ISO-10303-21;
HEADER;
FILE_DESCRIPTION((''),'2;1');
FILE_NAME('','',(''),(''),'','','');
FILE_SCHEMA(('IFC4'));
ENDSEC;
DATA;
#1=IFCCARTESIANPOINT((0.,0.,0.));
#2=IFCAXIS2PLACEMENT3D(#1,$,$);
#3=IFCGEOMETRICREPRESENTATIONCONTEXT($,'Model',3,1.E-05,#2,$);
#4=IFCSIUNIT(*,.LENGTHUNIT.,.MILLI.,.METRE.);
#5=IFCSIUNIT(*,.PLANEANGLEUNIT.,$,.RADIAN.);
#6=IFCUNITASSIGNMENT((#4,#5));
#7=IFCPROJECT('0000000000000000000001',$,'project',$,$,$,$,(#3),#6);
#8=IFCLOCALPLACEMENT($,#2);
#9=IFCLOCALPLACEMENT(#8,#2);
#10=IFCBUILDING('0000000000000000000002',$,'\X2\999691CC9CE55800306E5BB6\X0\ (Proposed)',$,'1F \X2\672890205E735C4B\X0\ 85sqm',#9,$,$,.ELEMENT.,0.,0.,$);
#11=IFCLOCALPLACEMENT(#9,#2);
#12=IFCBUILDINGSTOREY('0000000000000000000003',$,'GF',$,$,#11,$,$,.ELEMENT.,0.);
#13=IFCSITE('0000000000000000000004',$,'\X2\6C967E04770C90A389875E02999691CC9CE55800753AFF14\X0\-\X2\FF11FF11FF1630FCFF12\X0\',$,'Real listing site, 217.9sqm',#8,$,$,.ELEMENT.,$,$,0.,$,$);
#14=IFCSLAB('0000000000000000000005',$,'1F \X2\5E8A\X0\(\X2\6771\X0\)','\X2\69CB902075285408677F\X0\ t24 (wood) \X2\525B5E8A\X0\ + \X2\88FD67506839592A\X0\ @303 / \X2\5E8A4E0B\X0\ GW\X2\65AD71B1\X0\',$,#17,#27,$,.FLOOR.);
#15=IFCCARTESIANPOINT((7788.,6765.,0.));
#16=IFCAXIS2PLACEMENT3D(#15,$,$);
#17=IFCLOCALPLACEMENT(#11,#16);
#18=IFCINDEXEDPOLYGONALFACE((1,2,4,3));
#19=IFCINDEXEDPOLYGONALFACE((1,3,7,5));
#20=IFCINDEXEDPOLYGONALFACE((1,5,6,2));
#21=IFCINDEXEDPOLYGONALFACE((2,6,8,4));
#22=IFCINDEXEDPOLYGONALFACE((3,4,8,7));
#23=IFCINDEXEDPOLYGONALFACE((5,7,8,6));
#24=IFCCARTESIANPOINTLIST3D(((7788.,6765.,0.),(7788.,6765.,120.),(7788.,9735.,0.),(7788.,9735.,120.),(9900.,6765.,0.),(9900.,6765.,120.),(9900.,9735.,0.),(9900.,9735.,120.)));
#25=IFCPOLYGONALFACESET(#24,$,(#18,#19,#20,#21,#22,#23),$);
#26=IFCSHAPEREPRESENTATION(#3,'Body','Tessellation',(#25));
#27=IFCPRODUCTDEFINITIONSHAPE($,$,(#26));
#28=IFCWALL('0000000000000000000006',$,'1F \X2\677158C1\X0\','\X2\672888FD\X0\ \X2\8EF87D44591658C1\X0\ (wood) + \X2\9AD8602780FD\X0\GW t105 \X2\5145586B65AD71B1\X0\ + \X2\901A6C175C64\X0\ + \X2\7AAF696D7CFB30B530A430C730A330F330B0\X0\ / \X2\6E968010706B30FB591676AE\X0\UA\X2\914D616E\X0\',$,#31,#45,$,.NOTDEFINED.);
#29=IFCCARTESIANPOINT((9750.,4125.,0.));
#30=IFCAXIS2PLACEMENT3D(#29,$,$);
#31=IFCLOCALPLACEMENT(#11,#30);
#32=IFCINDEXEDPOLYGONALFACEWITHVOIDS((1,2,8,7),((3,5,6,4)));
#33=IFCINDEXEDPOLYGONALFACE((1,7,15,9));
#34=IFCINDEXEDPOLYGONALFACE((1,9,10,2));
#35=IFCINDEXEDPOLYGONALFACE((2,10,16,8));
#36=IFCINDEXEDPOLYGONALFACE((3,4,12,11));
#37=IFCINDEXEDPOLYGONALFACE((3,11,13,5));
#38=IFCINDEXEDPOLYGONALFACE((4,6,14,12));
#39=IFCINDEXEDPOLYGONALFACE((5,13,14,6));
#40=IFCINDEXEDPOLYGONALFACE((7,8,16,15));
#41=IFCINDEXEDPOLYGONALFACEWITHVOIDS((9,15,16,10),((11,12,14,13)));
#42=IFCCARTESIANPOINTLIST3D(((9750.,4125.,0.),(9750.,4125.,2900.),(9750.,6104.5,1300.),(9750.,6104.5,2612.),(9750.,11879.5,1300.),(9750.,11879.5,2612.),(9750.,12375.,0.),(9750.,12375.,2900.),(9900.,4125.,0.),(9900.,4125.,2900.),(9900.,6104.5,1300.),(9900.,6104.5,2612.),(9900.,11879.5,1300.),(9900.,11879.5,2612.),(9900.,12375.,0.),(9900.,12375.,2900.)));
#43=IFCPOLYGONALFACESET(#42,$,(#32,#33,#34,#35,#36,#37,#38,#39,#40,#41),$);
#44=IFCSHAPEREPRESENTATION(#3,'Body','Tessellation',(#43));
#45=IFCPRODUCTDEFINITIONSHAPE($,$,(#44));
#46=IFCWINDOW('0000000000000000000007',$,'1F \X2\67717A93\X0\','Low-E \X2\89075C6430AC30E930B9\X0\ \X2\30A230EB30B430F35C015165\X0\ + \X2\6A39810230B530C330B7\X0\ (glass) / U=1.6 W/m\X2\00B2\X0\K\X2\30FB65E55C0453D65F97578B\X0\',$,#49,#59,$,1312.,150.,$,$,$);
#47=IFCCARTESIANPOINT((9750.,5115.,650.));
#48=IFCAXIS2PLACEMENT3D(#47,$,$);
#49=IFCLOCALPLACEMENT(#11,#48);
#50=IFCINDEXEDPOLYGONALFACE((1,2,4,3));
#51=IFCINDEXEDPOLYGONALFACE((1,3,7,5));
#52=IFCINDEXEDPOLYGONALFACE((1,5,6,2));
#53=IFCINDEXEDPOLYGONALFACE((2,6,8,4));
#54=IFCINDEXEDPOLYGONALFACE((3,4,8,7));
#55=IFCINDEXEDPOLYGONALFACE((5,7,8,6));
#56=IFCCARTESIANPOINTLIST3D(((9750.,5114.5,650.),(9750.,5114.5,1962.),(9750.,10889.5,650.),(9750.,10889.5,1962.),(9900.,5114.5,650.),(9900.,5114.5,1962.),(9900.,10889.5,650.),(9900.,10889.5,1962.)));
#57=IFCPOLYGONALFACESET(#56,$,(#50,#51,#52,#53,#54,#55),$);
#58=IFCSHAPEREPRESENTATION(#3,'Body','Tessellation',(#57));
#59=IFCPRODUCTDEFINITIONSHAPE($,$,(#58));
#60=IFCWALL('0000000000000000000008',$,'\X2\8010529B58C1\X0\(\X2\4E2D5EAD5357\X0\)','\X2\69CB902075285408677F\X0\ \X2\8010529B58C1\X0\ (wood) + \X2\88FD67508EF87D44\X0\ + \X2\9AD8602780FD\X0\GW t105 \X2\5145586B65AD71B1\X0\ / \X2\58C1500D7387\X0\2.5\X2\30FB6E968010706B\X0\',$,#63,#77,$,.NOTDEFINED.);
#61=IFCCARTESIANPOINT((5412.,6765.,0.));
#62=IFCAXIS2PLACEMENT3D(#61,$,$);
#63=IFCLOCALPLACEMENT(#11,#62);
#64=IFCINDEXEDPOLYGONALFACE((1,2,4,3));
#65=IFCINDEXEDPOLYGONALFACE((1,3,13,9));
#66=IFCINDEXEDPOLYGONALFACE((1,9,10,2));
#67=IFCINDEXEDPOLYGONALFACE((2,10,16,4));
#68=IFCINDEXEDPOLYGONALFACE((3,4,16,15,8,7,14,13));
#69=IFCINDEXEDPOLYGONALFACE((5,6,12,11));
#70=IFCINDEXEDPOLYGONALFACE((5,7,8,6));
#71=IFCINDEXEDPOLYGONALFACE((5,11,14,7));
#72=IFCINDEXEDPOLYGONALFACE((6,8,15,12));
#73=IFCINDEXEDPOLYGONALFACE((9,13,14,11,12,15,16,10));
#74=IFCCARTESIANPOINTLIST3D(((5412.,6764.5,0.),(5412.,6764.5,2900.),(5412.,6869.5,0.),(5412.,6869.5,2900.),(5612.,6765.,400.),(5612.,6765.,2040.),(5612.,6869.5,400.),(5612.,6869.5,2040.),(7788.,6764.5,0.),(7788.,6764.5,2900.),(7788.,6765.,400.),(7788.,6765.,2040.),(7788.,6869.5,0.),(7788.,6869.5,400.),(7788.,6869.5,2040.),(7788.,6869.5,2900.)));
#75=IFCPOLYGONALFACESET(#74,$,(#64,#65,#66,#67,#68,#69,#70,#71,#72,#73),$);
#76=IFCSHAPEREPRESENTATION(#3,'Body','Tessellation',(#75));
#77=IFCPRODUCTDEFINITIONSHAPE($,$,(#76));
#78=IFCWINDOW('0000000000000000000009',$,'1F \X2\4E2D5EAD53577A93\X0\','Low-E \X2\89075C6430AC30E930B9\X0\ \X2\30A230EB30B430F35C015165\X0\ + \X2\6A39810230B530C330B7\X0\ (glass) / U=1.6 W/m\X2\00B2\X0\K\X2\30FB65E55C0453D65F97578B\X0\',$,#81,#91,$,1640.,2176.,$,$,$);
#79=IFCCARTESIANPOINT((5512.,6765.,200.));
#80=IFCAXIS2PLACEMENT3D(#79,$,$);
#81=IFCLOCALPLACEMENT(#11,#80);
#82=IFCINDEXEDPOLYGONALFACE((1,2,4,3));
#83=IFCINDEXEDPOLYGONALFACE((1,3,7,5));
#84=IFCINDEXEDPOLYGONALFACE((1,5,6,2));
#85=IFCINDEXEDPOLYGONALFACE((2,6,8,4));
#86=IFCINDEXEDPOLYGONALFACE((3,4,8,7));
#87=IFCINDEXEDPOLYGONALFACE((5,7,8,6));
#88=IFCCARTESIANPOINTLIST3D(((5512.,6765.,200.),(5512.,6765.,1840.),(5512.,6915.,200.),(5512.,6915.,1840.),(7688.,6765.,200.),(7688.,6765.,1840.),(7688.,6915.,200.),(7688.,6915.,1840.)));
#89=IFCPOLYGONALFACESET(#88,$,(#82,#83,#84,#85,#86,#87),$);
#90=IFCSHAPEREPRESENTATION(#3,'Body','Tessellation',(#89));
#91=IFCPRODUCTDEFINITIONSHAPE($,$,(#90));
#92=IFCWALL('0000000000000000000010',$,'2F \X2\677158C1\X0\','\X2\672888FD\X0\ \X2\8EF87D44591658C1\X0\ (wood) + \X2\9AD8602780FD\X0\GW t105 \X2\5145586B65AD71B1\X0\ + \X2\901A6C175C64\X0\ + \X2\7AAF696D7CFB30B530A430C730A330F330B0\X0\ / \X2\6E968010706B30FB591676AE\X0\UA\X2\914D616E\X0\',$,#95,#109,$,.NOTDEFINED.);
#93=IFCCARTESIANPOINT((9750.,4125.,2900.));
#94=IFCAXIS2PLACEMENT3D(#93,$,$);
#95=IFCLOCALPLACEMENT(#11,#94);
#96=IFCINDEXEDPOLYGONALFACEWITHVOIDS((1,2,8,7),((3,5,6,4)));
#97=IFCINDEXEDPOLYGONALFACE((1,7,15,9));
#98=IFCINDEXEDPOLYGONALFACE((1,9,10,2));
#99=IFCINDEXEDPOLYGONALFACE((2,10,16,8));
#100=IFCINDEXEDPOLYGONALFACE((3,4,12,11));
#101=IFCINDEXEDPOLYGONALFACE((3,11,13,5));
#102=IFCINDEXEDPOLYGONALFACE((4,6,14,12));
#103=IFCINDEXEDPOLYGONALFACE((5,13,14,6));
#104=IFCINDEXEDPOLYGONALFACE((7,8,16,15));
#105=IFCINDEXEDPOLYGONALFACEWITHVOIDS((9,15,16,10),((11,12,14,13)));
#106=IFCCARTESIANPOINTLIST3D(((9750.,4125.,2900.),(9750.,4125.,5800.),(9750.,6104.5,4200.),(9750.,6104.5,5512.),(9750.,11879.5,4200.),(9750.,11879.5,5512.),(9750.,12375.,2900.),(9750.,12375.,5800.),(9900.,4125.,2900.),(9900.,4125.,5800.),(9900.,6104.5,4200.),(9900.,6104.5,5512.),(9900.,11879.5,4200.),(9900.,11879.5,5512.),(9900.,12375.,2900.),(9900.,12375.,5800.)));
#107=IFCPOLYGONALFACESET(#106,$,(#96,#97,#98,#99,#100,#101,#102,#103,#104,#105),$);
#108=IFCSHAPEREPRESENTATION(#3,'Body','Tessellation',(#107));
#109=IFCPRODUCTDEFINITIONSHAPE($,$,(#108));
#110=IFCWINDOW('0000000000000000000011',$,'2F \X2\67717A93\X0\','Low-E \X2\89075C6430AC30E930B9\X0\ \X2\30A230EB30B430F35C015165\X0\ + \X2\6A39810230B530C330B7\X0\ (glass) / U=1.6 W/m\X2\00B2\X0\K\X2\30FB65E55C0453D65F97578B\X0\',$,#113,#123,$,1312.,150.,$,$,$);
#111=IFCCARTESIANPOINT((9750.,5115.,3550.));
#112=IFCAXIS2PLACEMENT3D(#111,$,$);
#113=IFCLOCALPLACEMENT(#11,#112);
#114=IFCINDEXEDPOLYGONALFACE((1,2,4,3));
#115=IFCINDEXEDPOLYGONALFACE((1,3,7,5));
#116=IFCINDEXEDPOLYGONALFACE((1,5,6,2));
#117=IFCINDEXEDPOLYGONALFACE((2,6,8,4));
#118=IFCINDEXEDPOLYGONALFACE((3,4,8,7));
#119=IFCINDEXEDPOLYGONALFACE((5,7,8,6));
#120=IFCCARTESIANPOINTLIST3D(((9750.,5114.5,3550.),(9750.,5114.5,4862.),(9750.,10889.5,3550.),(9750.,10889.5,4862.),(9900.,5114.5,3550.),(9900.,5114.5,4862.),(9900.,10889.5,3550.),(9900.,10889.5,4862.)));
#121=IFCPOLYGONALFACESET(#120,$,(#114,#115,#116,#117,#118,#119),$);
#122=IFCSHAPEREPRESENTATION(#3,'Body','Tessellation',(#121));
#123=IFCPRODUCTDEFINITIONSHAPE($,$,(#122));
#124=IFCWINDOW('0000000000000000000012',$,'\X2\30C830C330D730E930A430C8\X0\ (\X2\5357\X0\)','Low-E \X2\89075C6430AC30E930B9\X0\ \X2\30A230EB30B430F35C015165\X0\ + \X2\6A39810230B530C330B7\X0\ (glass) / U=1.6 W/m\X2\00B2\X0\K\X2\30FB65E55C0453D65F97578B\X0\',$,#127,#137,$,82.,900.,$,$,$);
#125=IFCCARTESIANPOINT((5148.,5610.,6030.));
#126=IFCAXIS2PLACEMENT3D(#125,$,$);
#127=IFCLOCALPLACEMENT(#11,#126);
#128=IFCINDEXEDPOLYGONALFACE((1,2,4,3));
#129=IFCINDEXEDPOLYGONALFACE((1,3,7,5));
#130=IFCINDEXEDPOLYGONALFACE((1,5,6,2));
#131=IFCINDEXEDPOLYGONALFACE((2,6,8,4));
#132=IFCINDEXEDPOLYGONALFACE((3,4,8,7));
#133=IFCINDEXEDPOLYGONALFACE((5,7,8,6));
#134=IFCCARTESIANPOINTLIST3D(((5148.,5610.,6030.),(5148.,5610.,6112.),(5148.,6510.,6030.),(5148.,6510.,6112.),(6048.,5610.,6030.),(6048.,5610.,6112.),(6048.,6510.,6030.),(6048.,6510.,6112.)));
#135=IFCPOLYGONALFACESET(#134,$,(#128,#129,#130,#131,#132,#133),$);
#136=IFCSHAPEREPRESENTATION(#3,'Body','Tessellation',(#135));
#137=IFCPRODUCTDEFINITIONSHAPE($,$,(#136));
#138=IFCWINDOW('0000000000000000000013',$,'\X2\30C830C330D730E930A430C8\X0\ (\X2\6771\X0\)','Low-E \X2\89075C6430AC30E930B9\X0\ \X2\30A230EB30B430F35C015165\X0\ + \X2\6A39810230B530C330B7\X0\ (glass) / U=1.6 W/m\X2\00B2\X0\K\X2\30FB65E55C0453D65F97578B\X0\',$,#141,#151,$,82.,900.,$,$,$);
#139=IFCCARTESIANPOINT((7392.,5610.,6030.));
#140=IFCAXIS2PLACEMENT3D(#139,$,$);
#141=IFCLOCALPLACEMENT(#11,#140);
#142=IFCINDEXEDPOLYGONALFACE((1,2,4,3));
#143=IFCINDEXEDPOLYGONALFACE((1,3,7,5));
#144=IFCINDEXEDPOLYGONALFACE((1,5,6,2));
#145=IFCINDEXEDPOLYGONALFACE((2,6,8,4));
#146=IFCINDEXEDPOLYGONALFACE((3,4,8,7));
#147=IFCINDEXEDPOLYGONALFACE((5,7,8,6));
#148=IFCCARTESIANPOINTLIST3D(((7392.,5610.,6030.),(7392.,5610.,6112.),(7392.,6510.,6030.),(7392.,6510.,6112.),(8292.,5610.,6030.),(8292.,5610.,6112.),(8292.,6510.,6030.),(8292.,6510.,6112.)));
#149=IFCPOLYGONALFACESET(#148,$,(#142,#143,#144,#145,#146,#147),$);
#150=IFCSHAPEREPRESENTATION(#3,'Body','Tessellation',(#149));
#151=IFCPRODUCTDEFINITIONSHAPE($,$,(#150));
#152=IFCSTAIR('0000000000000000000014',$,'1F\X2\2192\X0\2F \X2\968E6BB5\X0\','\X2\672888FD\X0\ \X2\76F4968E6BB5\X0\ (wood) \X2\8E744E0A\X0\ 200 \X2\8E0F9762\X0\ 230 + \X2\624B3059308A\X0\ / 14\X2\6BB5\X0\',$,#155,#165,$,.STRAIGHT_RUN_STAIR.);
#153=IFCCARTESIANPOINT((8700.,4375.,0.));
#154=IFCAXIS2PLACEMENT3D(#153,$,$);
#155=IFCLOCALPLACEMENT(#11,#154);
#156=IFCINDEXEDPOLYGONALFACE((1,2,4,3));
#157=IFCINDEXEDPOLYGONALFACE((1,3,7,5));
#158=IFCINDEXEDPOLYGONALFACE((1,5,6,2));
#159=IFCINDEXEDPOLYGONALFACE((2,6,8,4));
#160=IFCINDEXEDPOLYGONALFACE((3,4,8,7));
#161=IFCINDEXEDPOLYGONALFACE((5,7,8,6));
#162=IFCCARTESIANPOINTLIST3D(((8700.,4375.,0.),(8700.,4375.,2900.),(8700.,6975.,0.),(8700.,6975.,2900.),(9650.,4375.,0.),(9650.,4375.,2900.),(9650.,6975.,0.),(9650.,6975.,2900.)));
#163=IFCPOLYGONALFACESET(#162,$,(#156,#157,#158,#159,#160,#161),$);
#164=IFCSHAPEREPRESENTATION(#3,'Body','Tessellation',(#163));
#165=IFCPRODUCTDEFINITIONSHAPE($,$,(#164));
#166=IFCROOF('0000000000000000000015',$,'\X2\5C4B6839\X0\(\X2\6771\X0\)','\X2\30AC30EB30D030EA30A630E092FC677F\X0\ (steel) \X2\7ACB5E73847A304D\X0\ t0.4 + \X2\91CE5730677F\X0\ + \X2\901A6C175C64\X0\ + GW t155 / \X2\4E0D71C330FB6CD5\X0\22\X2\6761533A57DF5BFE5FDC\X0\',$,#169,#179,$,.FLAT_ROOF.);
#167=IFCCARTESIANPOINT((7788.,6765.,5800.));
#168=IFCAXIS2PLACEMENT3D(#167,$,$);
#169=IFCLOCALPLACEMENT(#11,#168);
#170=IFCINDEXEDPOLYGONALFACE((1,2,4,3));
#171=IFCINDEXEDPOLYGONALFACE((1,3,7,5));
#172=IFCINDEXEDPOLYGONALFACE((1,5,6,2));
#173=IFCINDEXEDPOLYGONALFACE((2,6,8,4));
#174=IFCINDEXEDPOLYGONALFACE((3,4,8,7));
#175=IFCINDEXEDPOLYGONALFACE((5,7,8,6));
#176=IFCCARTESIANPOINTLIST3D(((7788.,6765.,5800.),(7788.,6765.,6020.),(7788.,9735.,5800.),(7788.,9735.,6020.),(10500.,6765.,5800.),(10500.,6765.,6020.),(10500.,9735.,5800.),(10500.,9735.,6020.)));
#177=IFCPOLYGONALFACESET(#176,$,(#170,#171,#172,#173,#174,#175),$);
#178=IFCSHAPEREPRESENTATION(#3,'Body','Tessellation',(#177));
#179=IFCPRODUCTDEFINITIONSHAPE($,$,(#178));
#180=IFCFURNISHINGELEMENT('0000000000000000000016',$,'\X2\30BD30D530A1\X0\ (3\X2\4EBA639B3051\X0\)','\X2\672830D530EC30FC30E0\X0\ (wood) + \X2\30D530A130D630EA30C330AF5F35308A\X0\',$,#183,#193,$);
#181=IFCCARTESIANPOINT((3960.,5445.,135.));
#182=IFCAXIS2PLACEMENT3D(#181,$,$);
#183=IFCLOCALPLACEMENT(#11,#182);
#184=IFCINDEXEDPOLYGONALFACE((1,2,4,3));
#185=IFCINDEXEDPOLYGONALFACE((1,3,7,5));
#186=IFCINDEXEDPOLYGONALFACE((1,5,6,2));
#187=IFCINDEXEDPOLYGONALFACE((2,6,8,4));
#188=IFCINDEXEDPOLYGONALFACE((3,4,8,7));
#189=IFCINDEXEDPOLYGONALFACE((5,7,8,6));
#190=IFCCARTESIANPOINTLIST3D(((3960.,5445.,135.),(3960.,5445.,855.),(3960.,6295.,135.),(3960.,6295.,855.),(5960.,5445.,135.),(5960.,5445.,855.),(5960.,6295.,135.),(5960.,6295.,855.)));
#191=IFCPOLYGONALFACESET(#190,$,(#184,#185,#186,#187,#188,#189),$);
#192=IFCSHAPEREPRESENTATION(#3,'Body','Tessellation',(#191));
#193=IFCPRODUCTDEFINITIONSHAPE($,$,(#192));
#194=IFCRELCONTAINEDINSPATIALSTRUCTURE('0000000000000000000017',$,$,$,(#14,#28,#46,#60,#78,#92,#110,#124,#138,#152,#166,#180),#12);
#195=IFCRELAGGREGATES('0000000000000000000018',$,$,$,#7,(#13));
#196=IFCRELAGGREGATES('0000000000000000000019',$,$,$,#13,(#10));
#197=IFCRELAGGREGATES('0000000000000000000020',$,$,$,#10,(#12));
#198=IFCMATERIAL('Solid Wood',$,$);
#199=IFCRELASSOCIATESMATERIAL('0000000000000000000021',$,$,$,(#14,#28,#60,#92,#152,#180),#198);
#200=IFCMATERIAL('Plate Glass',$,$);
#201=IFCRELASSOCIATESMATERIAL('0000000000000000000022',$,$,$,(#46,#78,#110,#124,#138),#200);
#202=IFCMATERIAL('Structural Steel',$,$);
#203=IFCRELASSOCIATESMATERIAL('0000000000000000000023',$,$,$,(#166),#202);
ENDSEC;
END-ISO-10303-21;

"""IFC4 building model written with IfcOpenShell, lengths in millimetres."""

from ifc_helpers import new_model, si_unit, frame, frame_2d, origin, place, context, project, spatial, rectangle, extrude, material, element, fill, save


model = new_model("IFC4")

# Units and contexts
model_context = context("Model", 3, precision=1e-05, world=origin())
ifc_project = project(units=[si_unit("LENGTHUNIT", "METRE", prefix="MILLI"), si_unit("PLANEANGLEUNIT", "RADIAN")], contexts=[model_context])

# Site, building, storey
site_placement = place(None, origin())
site = spatial("IfcSite", under=ifc_project, at=site_placement, Name="沖縄県那覇市首里鳥堀町４-１１６ー２", ObjectType="Real listing site, 217.9sqm", CompositionType="ELEMENT", RefElevation=0.0)
building_placement = place(site_placement, origin())
building = spatial("IfcBuilding", under=site, at=building_placement, Name="首里鳥堀の家 (Proposed)", ObjectType="1F 木造平屋 85sqm", CompositionType="ELEMENT", ElevationOfRefHeight=0.0, ElevationOfTerrain=0.0)
storey_placement = place(building_placement, origin())
storey = spatial("IfcBuildingStorey", under=building, at=storey_placement, Name="GF", CompositionType="ELEMENT", Elevation=0.0)

# Slab
ifc_material_1 = material(Name="Solid Wood")
slab_placement = place(storey_placement, frame((7788.0, 6765.0, 0.0)))
element("IfcSlab", 1, at=slab_placement, inside=storey, material=ifc_material_1, Name="1F 床(東)", Description="構造用合板 t24 (wood) 剛床 + 製材根太 @303 / 床下 GW断熱", PredefinedType="FLOOR", context=model_context, shape_type="SweptSolid", body=[
    extrude(rectangle(XDim=2112.0, YDim=2970.0, at=frame_2d((1056.0, 1485.0))), frame((7788.0, 6765.0, 0.0)), (0.0, 0.0, 1.0), 120.0),
])

# Walls, openings, windows
wall_1_placement = place(storey_placement, frame((9750.0, 4125.0, 0.0)))
wall_1 = element("IfcWall", 2, at=wall_1_placement, inside=storey, material=ifc_material_1, Name="1F 東壁", Description="木製 軸組外壁 (wood) + 高性能GW t105 充填断熱 + 通気層 + 窯業系サイディング / 準耐火・外皮UA配慮", PredefinedType="NOTDEFINED", context=model_context, shape_type="SweptSolid", body=[
    extrude(rectangle(XDim=150.0, YDim=8250.0, at=frame_2d((75.0, 4125.0))), frame((9750.0, 4125.0, 0.0)), (0.0, 0.0, 1.0), 2900.0),
])
opening_1_placement = place(storey_placement, frame((9750.0, 5115.0, 650.0)))
opening_1 = element("IfcOpeningElement", 3, at=opening_1_placement, cuts=wall_1, PredefinedType="NOTDEFINED", context=model_context, shape_type="SweptSolid", body=[
    extrude(rectangle(XDim=150.0, YDim=5775.0, at=frame_2d((75.0, 2887.0))), frame((9750.0, 5115.0, 650.0)), (0.0, 0.0, 1.0), 1312.0),
])
ifc_material_2 = material(Name="Plate Glass")
window_1_placement = place(storey_placement, frame((9750.0, 5115.0, 650.0)))
window_1 = element("IfcWindow", 4, at=window_1_placement, inside=storey, material=ifc_material_2, Name="1F 東窓", Description="Low-E 複層ガラス アルゴン封入 + 樹脂サッシ (glass) / U=1.6 W/m²K・日射取得型", OverallHeight=1312.0, OverallWidth=150.0, context=model_context, shape_type="SweptSolid", body=[
    extrude(rectangle(XDim=150.0, YDim=5775.0, at=frame_2d((75.0, 2887.0))), frame((9750.0, 5115.0, 650.0)), (0.0, 0.0, 1.0), 1312.0),
])
fill(opening_1, window_1)
wall_2_placement = place(storey_placement, frame((5412.0, 6765.0, 0.0)))
wall_2 = element("IfcWall", 5, at=wall_2_placement, inside=storey, material=ifc_material_1, Name="耐力壁(中庭南)", Description="構造用合板 耐力壁 (wood) + 製材軸組 + 高性能GW t105 充填断熱 / 壁倍率2.5・準耐火", PredefinedType="NOTDEFINED", context=model_context, shape_type="SweptSolid", body=[
    extrude(rectangle(XDim=2376.0, YDim=105.0, at=frame_2d((1188.0, 52.0))), frame((5412.0, 6765.0, 0.0)), (0.0, 0.0, 1.0), 2900.0),
])
opening_2_placement = place(storey_placement, frame((5512.0, 6765.0, 200.0)))
opening_2 = element("IfcOpeningElement", 6, at=opening_2_placement, cuts=wall_2, PredefinedType="NOTDEFINED", context=model_context, shape_type="SweptSolid", body=[
    extrude(rectangle(XDim=2176.0, YDim=150.0, at=frame_2d((1088.0, 75.0))), frame((5512.0, 6765.0, 200.0)), (0.0, 0.0, 1.0), 1640.0),
])
window_2_placement = place(storey_placement, frame((5512.0, 6765.0, 200.0)))
window_2 = element("IfcWindow", 7, at=window_2_placement, inside=storey, material=ifc_material_2, Name="1F 中庭南窓", Description="Low-E 複層ガラス アルゴン封入 + 樹脂サッシ (glass) / U=1.6 W/m²K・日射取得型", OverallHeight=1640.0, OverallWidth=2176.0, context=model_context, shape_type="SweptSolid", body=[
    extrude(rectangle(XDim=2176.0, YDim=150.0, at=frame_2d((1088.0, 75.0))), frame((5512.0, 6765.0, 200.0)), (0.0, 0.0, 1.0), 1640.0),
])
fill(opening_2, window_2)

# Wall, opening, window
wall_3_placement = place(storey_placement, frame((9750.0, 4125.0, 2900.0)))
wall_3 = element("IfcWall", 8, at=wall_3_placement, inside=storey, material=ifc_material_1, Name="2F 東壁", Description="木製 軸組外壁 (wood) + 高性能GW t105 充填断熱 + 通気層 + 窯業系サイディング / 準耐火・外皮UA配慮", PredefinedType="NOTDEFINED", context=model_context, shape_type="SweptSolid", body=[
    extrude(rectangle(XDim=150.0, YDim=8250.0, at=frame_2d((75.0, 4125.0))), frame((9750.0, 4125.0, 2900.0)), (0.0, 0.0, 1.0), 2900.0),
])
opening_3_placement = place(storey_placement, frame((9750.0, 5115.0, 3550.0)))
opening_3 = element("IfcOpeningElement", 9, at=opening_3_placement, cuts=wall_3, PredefinedType="NOTDEFINED", context=model_context, shape_type="SweptSolid", body=[
    extrude(rectangle(XDim=150.0, YDim=5775.0, at=frame_2d((75.0, 2887.0))), frame((9750.0, 5115.0, 3550.0)), (0.0, 0.0, 1.0), 1312.0),
])
window_3_placement = place(storey_placement, frame((9750.0, 5115.0, 3550.0)))
window_3 = element("IfcWindow", 10, at=window_3_placement, inside=storey, material=ifc_material_2, Name="2F 東窓", Description="Low-E 複層ガラス アルゴン封入 + 樹脂サッシ (glass) / U=1.6 W/m²K・日射取得型", OverallHeight=1312.0, OverallWidth=150.0, context=model_context, shape_type="SweptSolid", body=[
    extrude(rectangle(XDim=150.0, YDim=5775.0, at=frame_2d((75.0, 2887.0))), frame((9750.0, 5115.0, 3550.0)), (0.0, 0.0, 1.0), 1312.0),
])
fill(opening_3, window_3)

# Windows
window_4_placement = place(storey_placement, frame((5148.0, 5610.0, 6030.0)))
element("IfcWindow", 11, at=window_4_placement, inside=storey, material=ifc_material_2, Name="トップライト (南)", Description="Low-E 複層ガラス アルゴン封入 + 樹脂サッシ (glass) / U=1.6 W/m²K・日射取得型", OverallHeight=82.0, OverallWidth=900.0, context=model_context, shape_type="SweptSolid", body=[
    extrude(rectangle(XDim=900.0, YDim=900.0, at=frame_2d((450.0, 450.0))), frame((5148.0, 5610.0, 6030.0)), (0.0, 0.0, 1.0), 82.0),
])
window_5_placement = place(storey_placement, frame((7392.0, 5610.0, 6030.0)))
element("IfcWindow", 12, at=window_5_placement, inside=storey, material=ifc_material_2, Name="トップライト (東)", Description="Low-E 複層ガラス アルゴン封入 + 樹脂サッシ (glass) / U=1.6 W/m²K・日射取得型", OverallHeight=82.0, OverallWidth=900.0, context=model_context, shape_type="SweptSolid", body=[
    extrude(rectangle(XDim=900.0, YDim=900.0, at=frame_2d((450.0, 450.0))), frame((7392.0, 5610.0, 6030.0)), (0.0, 0.0, 1.0), 82.0),
])

# Stair
stair_placement = place(storey_placement, frame((8700.0, 4375.0, 0.0)))
element("IfcStair", 13, at=stair_placement, inside=storey, material=ifc_material_1, Name="1F→2F 階段", Description="木製 直階段 (wood) 蹴上 200 踏面 230 + 手すり / 14段", PredefinedType="STRAIGHT_RUN_STAIR", context=model_context, shape_type="SweptSolid", body=[
    extrude(rectangle(XDim=950.0, YDim=2600.0, at=frame_2d((475.0, 1300.0))), frame((8700.0, 4375.0, 0.0)), (0.0, 0.0, 1.0), 2900.0),
])

# Roof
ifc_material_3 = material(Name="Structural Steel")
roof_placement = place(storey_placement, frame((7788.0, 6765.0, 5800.0)))
element("IfcRoof", 14, at=roof_placement, inside=storey, material=ifc_material_3, Name="屋根(東)", Description="ガルバリウム鋼板 (steel) 立平葺き t0.4 + 野地板 + 通気層 + GW t155 / 不燃・法22条区域対応", PredefinedType="FLAT_ROOF", context=model_context, shape_type="SweptSolid", body=[
    extrude(rectangle(XDim=2712.0, YDim=2970.0, at=frame_2d((1356.0, 1485.0))), frame((7788.0, 6765.0, 5800.0)), (0.0, 0.0, 1.0), 220.0),
])

# Furnishing element
furnishing_1_placement = place(storey_placement, frame((3960.0, 5445.0, 135.0)))
element("IfcFurnishingElement", 15, at=furnishing_1_placement, inside=storey, material=ifc_material_1, Name="ソファ (3人掛け)", Description="木フレーム (wood) + ファブリック張り", context=model_context, shape_type="SweptSolid", body=[
    extrude(rectangle(XDim=2000.0, YDim=850.0, at=frame_2d((1000.0, 425.0))), frame((3960.0, 5445.0, 135.0)), (0.0, 0.0, 1.0), 720.0),
])

save(model, "model.ifc")
